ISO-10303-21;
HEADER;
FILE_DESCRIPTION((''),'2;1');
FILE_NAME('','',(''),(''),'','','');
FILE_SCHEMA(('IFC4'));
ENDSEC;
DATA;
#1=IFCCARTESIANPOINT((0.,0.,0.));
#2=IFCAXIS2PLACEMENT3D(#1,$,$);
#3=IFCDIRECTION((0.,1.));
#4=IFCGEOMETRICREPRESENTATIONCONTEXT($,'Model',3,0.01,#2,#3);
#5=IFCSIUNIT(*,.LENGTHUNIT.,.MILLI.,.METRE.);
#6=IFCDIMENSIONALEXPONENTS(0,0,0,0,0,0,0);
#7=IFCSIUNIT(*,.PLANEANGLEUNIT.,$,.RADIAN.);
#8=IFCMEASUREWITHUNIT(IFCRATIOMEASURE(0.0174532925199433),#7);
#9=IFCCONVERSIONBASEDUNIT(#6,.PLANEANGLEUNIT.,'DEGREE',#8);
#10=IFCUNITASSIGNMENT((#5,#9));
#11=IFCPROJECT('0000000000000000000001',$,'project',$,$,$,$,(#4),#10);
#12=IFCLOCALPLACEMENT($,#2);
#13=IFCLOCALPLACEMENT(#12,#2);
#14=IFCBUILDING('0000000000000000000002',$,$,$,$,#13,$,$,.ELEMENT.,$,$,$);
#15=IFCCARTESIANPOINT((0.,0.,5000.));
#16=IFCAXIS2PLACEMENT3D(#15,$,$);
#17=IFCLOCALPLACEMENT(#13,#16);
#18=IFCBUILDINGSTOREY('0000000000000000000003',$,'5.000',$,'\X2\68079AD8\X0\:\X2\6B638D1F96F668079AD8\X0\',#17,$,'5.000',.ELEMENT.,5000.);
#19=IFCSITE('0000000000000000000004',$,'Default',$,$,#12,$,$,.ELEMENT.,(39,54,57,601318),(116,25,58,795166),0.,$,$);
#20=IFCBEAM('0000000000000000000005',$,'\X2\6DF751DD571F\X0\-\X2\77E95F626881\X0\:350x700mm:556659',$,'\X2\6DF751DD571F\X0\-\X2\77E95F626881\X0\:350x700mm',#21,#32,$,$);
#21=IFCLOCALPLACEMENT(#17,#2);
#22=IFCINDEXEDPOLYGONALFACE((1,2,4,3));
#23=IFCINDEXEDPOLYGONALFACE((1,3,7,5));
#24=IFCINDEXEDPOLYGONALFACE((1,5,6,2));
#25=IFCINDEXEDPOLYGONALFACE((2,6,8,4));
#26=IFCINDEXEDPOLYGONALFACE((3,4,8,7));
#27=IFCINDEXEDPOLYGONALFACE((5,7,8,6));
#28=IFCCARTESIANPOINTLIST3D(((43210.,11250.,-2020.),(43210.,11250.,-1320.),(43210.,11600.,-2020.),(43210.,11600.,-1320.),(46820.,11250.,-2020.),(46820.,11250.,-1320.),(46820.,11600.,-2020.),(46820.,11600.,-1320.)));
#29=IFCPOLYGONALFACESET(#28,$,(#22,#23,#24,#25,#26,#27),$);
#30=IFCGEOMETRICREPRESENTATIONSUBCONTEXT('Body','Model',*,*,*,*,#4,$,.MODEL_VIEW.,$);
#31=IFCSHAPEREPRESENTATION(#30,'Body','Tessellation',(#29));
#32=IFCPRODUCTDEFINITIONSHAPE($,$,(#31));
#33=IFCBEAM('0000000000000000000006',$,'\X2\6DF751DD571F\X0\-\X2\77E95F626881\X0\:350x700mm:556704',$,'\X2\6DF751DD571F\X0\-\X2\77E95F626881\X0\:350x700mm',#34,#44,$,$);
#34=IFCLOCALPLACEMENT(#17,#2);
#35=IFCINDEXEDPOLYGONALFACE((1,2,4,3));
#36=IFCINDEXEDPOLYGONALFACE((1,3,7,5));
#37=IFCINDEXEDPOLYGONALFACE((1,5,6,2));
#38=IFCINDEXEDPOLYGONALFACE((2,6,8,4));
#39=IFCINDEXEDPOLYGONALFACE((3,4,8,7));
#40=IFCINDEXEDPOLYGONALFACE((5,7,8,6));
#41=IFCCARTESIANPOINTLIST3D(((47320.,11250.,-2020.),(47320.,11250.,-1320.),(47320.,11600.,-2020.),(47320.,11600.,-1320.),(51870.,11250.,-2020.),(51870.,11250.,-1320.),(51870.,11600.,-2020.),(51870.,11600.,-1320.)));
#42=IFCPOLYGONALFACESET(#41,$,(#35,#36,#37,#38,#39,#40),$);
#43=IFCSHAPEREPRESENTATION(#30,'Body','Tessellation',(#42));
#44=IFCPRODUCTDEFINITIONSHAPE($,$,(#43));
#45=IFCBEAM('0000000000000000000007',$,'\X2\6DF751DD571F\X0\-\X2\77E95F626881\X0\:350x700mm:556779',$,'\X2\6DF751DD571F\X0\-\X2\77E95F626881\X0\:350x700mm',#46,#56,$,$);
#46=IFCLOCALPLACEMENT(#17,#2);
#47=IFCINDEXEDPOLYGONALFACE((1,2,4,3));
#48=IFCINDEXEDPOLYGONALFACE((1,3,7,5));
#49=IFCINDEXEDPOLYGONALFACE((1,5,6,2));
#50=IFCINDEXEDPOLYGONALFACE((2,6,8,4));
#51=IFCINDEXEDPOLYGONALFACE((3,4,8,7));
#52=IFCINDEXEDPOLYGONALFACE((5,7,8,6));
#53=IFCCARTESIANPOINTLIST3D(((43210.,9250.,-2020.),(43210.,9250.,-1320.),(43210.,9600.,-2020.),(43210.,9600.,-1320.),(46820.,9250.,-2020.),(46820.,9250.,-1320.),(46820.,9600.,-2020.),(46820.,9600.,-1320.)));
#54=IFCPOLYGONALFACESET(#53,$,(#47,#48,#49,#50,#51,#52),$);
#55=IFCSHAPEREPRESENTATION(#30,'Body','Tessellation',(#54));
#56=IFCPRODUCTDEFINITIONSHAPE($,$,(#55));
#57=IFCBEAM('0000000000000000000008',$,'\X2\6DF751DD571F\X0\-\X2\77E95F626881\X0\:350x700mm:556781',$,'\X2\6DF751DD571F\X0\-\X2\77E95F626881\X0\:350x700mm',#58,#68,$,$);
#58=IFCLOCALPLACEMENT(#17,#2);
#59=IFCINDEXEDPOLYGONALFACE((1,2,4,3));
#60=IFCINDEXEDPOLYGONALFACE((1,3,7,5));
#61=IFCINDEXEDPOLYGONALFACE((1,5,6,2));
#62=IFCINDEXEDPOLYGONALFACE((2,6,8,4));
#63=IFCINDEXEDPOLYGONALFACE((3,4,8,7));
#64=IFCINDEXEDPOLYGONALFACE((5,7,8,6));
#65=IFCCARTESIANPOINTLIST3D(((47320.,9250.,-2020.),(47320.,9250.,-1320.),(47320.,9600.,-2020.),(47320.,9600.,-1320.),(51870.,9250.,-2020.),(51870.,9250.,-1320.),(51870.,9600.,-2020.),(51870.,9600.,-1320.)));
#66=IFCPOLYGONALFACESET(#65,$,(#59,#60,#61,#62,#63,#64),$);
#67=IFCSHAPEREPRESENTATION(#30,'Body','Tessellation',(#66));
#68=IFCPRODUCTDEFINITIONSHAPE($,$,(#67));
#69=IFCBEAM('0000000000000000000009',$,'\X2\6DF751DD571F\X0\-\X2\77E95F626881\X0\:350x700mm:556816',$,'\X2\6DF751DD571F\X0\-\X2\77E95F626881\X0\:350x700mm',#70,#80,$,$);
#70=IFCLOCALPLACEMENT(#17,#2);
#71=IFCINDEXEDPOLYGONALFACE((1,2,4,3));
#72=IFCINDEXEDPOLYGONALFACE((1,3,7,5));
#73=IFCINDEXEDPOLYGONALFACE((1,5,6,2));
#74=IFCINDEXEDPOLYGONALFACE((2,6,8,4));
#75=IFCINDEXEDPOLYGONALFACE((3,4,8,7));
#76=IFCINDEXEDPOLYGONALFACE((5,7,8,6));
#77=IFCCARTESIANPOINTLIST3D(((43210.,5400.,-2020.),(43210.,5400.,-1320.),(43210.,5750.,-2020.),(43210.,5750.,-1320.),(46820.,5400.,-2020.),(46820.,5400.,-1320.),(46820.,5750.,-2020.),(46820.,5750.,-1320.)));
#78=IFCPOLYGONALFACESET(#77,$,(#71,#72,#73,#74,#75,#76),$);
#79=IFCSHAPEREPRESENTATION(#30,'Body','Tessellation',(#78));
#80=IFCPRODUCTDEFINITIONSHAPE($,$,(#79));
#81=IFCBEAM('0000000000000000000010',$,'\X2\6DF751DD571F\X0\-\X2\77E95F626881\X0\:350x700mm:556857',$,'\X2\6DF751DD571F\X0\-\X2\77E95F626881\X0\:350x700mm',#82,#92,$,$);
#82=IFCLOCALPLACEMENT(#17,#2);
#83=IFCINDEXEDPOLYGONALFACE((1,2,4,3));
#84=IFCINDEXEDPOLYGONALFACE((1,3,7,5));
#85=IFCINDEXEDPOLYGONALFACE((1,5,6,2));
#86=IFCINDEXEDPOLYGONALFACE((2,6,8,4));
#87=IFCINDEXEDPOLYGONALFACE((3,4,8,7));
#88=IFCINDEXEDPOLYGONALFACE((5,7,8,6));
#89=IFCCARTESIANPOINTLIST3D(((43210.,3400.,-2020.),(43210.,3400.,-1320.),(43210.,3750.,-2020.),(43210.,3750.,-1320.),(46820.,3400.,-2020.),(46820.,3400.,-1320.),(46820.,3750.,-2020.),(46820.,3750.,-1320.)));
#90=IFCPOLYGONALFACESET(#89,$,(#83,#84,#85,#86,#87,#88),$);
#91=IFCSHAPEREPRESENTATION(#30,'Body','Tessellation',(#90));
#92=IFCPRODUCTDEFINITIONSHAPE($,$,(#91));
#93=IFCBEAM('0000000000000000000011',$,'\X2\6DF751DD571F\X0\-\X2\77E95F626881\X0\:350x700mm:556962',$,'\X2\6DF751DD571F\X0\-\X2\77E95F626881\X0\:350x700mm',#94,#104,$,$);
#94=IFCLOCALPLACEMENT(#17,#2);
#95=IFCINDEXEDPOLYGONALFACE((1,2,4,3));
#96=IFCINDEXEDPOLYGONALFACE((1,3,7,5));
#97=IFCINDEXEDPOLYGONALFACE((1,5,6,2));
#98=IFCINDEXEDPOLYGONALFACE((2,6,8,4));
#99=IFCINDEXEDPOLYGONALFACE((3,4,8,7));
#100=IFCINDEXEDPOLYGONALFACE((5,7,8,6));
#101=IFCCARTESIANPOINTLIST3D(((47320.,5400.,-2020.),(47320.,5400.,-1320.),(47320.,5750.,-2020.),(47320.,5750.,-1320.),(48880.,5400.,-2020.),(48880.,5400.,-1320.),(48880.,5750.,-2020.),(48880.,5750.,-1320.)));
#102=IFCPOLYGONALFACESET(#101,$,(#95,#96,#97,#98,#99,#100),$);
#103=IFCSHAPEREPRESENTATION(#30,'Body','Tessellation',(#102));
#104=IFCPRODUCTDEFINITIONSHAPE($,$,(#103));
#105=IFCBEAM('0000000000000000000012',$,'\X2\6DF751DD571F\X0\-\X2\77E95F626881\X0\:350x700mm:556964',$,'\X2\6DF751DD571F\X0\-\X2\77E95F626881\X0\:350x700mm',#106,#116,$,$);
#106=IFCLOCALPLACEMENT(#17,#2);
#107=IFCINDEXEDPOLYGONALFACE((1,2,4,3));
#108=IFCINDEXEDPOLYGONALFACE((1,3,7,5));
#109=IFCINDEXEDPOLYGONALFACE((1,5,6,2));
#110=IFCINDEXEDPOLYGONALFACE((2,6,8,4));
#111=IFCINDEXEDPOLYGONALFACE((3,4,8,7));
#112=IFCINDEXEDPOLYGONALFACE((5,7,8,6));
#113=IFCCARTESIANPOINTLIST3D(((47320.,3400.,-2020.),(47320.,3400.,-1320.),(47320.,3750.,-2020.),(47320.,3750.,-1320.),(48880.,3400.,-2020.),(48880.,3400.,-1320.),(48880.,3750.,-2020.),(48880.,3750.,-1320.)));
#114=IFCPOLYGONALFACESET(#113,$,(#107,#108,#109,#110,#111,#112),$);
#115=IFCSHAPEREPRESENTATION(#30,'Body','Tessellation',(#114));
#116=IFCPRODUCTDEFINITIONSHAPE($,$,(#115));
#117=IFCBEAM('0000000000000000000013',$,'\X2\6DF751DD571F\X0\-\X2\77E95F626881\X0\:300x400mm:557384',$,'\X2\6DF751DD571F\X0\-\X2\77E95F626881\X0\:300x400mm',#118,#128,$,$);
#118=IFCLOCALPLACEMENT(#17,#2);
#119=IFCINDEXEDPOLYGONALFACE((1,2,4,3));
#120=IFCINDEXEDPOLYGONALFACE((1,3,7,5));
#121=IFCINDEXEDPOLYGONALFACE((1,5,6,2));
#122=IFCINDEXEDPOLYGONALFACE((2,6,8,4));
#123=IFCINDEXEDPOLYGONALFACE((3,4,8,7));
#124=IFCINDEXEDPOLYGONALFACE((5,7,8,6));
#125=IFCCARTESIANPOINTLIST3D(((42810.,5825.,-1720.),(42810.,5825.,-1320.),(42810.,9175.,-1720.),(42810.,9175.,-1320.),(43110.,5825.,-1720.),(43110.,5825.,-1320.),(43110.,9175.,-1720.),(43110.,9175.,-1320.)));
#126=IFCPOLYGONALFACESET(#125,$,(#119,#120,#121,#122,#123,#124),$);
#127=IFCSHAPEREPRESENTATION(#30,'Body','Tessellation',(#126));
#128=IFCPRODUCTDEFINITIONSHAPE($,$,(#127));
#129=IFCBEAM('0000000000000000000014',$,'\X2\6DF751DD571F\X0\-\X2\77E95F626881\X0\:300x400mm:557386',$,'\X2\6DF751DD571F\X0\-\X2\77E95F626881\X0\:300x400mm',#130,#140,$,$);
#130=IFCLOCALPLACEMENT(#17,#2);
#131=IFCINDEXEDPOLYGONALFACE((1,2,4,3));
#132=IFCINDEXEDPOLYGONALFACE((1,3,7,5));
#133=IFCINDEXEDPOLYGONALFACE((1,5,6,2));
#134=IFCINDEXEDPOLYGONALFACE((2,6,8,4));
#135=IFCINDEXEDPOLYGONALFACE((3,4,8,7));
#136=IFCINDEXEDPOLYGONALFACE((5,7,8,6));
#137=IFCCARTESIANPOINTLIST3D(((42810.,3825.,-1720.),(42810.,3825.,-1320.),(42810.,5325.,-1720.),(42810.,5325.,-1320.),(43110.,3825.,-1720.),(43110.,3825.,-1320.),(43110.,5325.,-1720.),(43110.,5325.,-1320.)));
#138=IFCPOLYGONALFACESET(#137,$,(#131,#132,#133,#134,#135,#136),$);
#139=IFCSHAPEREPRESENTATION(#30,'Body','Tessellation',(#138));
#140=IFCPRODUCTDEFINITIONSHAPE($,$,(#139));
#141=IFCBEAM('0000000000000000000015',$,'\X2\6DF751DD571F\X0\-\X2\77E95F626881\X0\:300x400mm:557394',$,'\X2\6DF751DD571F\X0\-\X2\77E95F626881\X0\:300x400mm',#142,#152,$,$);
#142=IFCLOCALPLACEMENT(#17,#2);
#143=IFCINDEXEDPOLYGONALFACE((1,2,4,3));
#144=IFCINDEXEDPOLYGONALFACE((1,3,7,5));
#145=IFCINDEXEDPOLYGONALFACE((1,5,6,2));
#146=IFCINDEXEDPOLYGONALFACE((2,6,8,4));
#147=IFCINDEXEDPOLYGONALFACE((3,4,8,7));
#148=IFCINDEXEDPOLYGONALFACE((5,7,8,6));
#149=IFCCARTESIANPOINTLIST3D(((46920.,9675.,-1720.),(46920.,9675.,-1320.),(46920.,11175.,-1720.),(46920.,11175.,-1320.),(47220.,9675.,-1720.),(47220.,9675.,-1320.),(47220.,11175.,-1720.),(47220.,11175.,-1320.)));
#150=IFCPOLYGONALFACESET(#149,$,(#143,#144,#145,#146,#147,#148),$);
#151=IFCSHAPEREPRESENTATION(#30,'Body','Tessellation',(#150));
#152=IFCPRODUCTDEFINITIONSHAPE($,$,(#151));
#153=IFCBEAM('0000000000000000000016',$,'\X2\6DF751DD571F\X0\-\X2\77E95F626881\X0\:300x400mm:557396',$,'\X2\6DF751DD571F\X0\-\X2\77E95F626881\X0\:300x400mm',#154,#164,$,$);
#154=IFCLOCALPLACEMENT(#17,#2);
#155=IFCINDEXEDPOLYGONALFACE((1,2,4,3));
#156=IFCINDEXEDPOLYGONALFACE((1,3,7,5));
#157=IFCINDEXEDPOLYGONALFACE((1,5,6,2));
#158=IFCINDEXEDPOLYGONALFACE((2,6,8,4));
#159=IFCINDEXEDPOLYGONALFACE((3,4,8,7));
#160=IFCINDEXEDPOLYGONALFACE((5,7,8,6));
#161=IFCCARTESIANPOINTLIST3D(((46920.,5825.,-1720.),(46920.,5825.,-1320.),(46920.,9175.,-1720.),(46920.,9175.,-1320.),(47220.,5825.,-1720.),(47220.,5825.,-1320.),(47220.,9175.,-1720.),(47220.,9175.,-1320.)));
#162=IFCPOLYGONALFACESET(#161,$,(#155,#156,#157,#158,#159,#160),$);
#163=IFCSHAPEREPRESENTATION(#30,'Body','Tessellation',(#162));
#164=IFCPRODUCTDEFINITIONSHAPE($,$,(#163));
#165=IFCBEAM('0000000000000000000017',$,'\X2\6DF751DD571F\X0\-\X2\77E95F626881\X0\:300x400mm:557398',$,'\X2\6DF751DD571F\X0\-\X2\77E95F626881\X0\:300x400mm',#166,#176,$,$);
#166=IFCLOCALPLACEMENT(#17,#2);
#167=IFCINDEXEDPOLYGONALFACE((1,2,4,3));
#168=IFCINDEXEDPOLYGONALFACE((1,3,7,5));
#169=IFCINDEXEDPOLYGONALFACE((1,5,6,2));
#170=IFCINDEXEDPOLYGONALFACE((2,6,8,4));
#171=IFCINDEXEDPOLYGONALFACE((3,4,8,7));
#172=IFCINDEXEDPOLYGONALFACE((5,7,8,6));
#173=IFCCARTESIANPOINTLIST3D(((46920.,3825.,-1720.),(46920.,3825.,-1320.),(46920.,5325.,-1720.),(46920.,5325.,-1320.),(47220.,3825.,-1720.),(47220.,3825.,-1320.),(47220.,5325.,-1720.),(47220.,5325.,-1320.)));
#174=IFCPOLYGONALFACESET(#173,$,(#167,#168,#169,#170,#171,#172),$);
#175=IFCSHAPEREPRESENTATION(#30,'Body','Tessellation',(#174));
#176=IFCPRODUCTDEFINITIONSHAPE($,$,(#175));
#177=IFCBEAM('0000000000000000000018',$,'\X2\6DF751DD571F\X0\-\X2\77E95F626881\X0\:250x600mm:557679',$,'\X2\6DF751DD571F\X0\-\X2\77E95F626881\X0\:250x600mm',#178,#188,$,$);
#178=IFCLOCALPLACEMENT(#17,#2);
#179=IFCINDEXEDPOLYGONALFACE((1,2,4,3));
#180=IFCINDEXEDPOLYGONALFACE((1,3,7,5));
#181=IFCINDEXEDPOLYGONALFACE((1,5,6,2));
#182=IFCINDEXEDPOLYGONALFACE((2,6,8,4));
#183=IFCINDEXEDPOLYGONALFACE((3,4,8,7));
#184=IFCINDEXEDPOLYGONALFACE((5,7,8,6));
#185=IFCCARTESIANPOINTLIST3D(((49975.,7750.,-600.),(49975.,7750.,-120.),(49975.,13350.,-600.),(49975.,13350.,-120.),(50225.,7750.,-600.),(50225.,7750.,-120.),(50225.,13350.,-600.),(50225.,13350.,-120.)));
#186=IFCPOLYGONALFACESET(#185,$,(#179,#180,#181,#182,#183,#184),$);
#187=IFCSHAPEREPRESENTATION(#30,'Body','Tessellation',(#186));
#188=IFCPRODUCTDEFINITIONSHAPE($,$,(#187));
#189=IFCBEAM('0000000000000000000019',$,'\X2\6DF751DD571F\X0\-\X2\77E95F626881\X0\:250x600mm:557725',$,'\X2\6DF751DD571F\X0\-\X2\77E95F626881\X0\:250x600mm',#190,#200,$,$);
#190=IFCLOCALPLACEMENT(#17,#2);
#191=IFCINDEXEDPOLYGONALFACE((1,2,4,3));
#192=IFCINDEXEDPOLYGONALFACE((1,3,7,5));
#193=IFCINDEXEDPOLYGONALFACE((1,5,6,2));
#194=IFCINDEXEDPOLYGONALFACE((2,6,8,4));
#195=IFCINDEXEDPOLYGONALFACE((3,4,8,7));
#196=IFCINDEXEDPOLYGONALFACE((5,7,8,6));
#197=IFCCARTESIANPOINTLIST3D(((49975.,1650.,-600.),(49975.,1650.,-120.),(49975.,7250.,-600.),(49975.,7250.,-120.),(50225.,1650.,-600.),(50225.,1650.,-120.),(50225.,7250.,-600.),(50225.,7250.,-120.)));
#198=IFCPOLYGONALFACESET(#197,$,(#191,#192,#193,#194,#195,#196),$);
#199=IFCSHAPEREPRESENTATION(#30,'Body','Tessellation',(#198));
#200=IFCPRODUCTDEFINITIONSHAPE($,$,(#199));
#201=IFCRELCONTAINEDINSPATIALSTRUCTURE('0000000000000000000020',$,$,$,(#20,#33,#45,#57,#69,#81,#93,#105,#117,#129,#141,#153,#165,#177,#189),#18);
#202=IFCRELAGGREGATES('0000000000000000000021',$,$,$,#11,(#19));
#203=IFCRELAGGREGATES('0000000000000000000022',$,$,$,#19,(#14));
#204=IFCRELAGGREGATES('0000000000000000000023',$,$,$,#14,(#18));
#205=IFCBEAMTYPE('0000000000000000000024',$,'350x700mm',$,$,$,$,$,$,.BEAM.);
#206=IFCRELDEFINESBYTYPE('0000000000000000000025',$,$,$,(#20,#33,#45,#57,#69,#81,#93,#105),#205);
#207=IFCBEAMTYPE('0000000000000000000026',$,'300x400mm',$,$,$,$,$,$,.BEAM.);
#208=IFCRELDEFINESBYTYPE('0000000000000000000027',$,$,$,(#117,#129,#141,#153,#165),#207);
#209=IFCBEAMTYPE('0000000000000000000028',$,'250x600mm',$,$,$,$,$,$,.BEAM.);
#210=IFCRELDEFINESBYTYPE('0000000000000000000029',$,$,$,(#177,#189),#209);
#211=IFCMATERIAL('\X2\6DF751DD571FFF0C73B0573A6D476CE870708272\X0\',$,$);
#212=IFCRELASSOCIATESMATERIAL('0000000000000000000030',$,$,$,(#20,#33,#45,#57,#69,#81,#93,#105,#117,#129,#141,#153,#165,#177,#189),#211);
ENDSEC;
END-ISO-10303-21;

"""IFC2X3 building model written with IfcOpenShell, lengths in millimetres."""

from ifc_helpers import new_model, entity, si_unit, converted_unit, direction, frame, frame_2d, origin, origin_2d_with_axis, place, context, subcontext, project, spatial, rectangle, extrude, material, type_object, element, save


model = new_model("IFC2X3")

# Units and contexts
model_context = context("Model", 3, precision=0.01, world=origin(), true_north=direction((0.0, 1.0)))
body_context = subcontext(model_context, "Body", "Model", "MODEL_VIEW")
ifc_project = project(units=[si_unit("LENGTHUNIT", "METRE", prefix="MILLI"), converted_unit("PLANEANGLEUNIT", "DEGREE", entity("IfcRatioMeasure", 0.0174532925199433), si_unit("PLANEANGLEUNIT", "RADIAN"), dimensions=[0, 0, 0, 0, 0, 0, 0])], contexts=[model_context])

# Site, building, storey
site_placement = place(None, origin())
site = spatial("IfcSite", under=ifc_project, at=site_placement, Name="Default", CompositionType="ELEMENT", RefLatitude=(39, 54, 57, 601318), RefLongitude=(116, 25, 58, 795166), RefElevation=0.0)
building_placement = place(site_placement, origin())
building = spatial("IfcBuilding", under=site, at=building_placement, CompositionType="ELEMENT")
storey_placement = place(building_placement, frame((0.0, 0.0, 5000.0)))
storey = spatial("IfcBuildingStorey", under=building, at=storey_placement, Name="5.000", ObjectType="标高:正负零标高", LongName="5.000", CompositionType="ELEMENT", Elevation=5000.0)

# Beams
ifc_material_1 = material(Name="混凝土，现场浇注灰色")
beam_type_1 = type_object("IfcBeamType", Name="350x700mm", PredefinedType="BEAM")
beam_1_placement = place(storey_placement, frame((43210.0, 11425.0, -1320.0)))
element("IfcBeam", 1, at=beam_1_placement, inside=storey, type_object=beam_type_1, material=ifc_material_1, Name="混凝土-矩形梁:350x700mm:556659", ObjectType="混凝土-矩形梁:350x700mm", context=body_context, shape_type="SweptSolid", body=[
    extrude(rectangle(XDim=700.0, YDim=350.0, at=frame_2d((0.0, 0.0), x_axis=(1.0, 0.0))), frame((0.0, 0.0, -350.0), z_axis=(1.0, 0.0, 0.0), x_axis=(0.0, 0.0, -1.0)), (0.0, 0.0, 1.0), 3610.0),
])
beam_2_placement = place(storey_placement, frame((47320.0, 11425.0, -1320.0)))
element("IfcBeam", 2, at=beam_2_placement, inside=storey, type_object=beam_type_1, material=ifc_material_1, Name="混凝土-矩形梁:350x700mm:556704", ObjectType="混凝土-矩形梁:350x700mm", context=body_context, shape_type="SweptSolid", body=[
    extrude(rectangle(XDim=700.0, YDim=350.0, at=frame_2d((0.0, 0.0), x_axis=(1.0, 0.0))), frame((0.0, 0.0, -350.0), z_axis=(1.0, 0.0, 0.0), x_axis=(0.0, 0.0, -1.0)), (0.0, 0.0, 1.0), 4550.0),
])
beam_3_placement = place(storey_placement, frame((43210.0, 9425.0, -1320.0)))
element("IfcBeam", 3, at=beam_3_placement, inside=storey, type_object=beam_type_1, material=ifc_material_1, Name="混凝土-矩形梁:350x700mm:556779", ObjectType="混凝土-矩形梁:350x700mm", context=body_context, shape_type="SweptSolid", body=[
    extrude(rectangle(XDim=700.0, YDim=350.0, at=frame_2d((0.0, 0.0), x_axis=(1.0, 0.0))), frame((0.0, 0.0, -350.0), z_axis=(1.0, 0.0, 0.0), x_axis=(0.0, 0.0, -1.0)), (0.0, 0.0, 1.0), 3610.0),
])
beam_4_placement = place(storey_placement, frame((47320.0, 9425.0, -1320.0)))
element("IfcBeam", 4, at=beam_4_placement, inside=storey, type_object=beam_type_1, material=ifc_material_1, Name="混凝土-矩形梁:350x700mm:556781", ObjectType="混凝土-矩形梁:350x700mm", context=body_context, shape_type="SweptSolid", body=[
    extrude(rectangle(XDim=700.0, YDim=350.0, at=frame_2d((0.0, 0.0), x_axis=(1.0, 0.0))), frame((0.0, 0.0, -350.0), z_axis=(1.0, 0.0, 0.0), x_axis=(0.0, 0.0, -1.0)), (0.0, 0.0, 1.0), 4550.0),
])
for number, where, name in (
    (5, (43210.0, 5575.0, -1320.0), "混凝土-矩形梁:350x700mm:556816"),
    (6, (43210.0, 3575.0, -1320.0), "混凝土-矩形梁:350x700mm:556857"),
):
    element("IfcBeam", number, at=place(storey_placement, frame(where)), inside=storey, type_object=beam_type_1, material=ifc_material_1, Name=name, ObjectType="混凝土-矩形梁:350x700mm", context=body_context, shape_type="SweptSolid", body=[
        extrude(rectangle(XDim=700.0, YDim=350.0, at=frame_2d((0.0, 0.0), x_axis=(1.0, 0.0))), frame((0.0, 0.0, -350.0), z_axis=(1.0, 0.0, 0.0), x_axis=(0.0, 0.0, -1.0)), (0.0, 0.0, 1.0), 3610.0),
    ])
beam_5_placement = place(storey_placement, frame((47320.0, 5575.0, -1320.0)))
element("IfcBeam", 7, at=beam_5_placement, inside=storey, type_object=beam_type_1, material=ifc_material_1, Name="混凝土-矩形梁:350x700mm:556962", ObjectType="混凝土-矩形梁:350x700mm", context=body_context, shape_type="SweptSolid", body=[
    extrude(rectangle(XDim=700.0, YDim=350.0, at=frame_2d((0.0, 0.0), x_axis=(1.0, 0.0))), frame((0.0, 0.0, -350.0), z_axis=(1.0, 0.0, 0.0), x_axis=(0.0, 0.0, -1.0)), (0.0, 0.0, 1.0), 1560.0),
])
beam_6_placement = place(storey_placement, frame((47320.0, 3575.0, -1320.0)))
element("IfcBeam", 8, at=beam_6_placement, inside=storey, type_object=beam_type_1, material=ifc_material_1, Name="混凝土-矩形梁:350x700mm:556964", ObjectType="混凝土-矩形梁:350x700mm", context=body_context, shape_type="SweptSolid", body=[
    extrude(rectangle(XDim=700.0, YDim=350.0, at=frame_2d((0.0, 0.0), x_axis=(1.0, 0.0))), frame((0.0, 0.0, -350.0), z_axis=(1.0, 0.0, 0.0), x_axis=(0.0, 0.0, -1.0)), (0.0, 0.0, 1.0), 1560.0),
])
beam_type_2 = type_object("IfcBeamType", Name="300x400mm", PredefinedType="BEAM")
beam_7_placement = place(storey_placement, frame((42960.0, 9175.0, -1320.0), z_axis=(0.0, 0.0, 1.0), x_axis=(0.0, -1.0, 0.0)))
element("IfcBeam", 9, at=beam_7_placement, inside=storey, type_object=beam_type_2, material=ifc_material_1, Name="混凝土-矩形梁:300x400mm:557384", ObjectType="混凝土-矩形梁:300x400mm", context=body_context, shape_type="SweptSolid", body=[
    extrude(rectangle(XDim=400.0, YDim=300.0, at=origin_2d_with_axis()), frame((0.0, 0.0, -200.0), z_axis=(1.0, 0.0, 0.0), x_axis=(0.0, 0.0, -1.0)), (0.0, 0.0, 1.0), 3350.0),
])
beam_8_placement = place(storey_placement, frame((42960.0, 5325.0, -1320.0), z_axis=(0.0, 0.0, 1.0), x_axis=(0.0, -1.0, 0.0)))
element("IfcBeam", 10, at=beam_8_placement, inside=storey, type_object=beam_type_2, material=ifc_material_1, Name="混凝土-矩形梁:300x400mm:557386", ObjectType="混凝土-矩形梁:300x400mm", context=body_context, shape_type="SweptSolid", body=[
    extrude(rectangle(XDim=400.0, YDim=300.0, at=frame_2d((0.0, 0.0), x_axis=(1.0, 0.0))), frame((0.0, 0.0, -200.0), z_axis=(1.0, 0.0, 0.0), x_axis=(0.0, 0.0, -1.0)), (0.0, 0.0, 1.0), 1500.0),
])
beam_9_placement = place(storey_placement, frame((47070.0, 11175.0, -1320.0), z_axis=(0.0, 0.0, 1.0), x_axis=(0.0, -1.0, 0.0)))
element("IfcBeam", 11, at=beam_9_placement, inside=storey, type_object=beam_type_2, material=ifc_material_1, Name="混凝土-矩形梁:300x400mm:557394", ObjectType="混凝土-矩形梁:300x400mm", context=body_context, shape_type="SweptSolid", body=[
    extrude(rectangle(XDim=400.0, YDim=300.0, at=frame_2d((0.0, 0.0), x_axis=(1.0, 0.0))), frame((0.0, 0.0, -200.0), z_axis=(1.0, 0.0, 0.0), x_axis=(0.0, 0.0, -1.0)), (0.0, 0.0, 1.0), 1500.0),
])
beam_10_placement = place(storey_placement, frame((47070.0, 9175.0, -1320.0), z_axis=(0.0, 0.0, 1.0), x_axis=(0.0, -1.0, 0.0)))
element("IfcBeam", 12, at=beam_10_placement, inside=storey, type_object=beam_type_2, material=ifc_material_1, Name="混凝土-矩形梁:300x400mm:557396", ObjectType="混凝土-矩形梁:300x400mm", context=body_context, shape_type="SweptSolid", body=[
    extrude(rectangle(XDim=400.0, YDim=300.0, at=origin_2d_with_axis()), frame((0.0, 0.0, -200.0), z_axis=(1.0, 0.0, 0.0), x_axis=(0.0, 0.0, -1.0)), (0.0, 0.0, 1.0), 3350.0),
])
beam_11_placement = place(storey_placement, frame((47070.0, 5325.0, -1320.0), z_axis=(0.0, 0.0, 1.0), x_axis=(0.0, -1.0, 0.0)))
element("IfcBeam", 13, at=beam_11_placement, inside=storey, type_object=beam_type_2, material=ifc_material_1, Name="混凝土-矩形梁:300x400mm:557398", ObjectType="混凝土-矩形梁:300x400mm", context=body_context, shape_type="SweptSolid", body=[
    extrude(rectangle(XDim=400.0, YDim=300.0, at=frame_2d((0.0, 0.0), x_axis=(1.0, 0.0))), frame((0.0, 0.0, -200.0), z_axis=(1.0, 0.0, 0.0), x_axis=(0.0, 0.0, -1.0)), (0.0, 0.0, 1.0), 1500.0),
])
beam_type_3 = type_object("IfcBeamType", Name="250x600mm", PredefinedType="BEAM")
for number, where, z_axis, x_axis, name in (
    (14, (50100.0, 13600.0, 0.0), (0.0, 0.0, 1.0), (0.0, -1.0, 0.0), "混凝土-矩形梁:250x600mm:557679"),
    (15, (50100.0, 7500.0, 0.0), (0.0, 0.0, 1.0), (0.0, -1.0, 0.0), "混凝土-矩形梁:250x600mm:557725"),
):
    element("IfcBeam", number, at=place(storey_placement, frame(where, z_axis=z_axis, x_axis=x_axis)), inside=storey, type_object=beam_type_3, material=ifc_material_1, Name=name, ObjectType="混凝土-矩形梁:250x600mm", context=body_context, shape_type="SweptSolid", body=[
        extrude(rectangle(XDim=480.0, YDim=250.0, at=frame_2d((0.0, 0.0), x_axis=(1.0, 0.0))), frame((250.0, 0.0, -360.0), z_axis=(1.0, 0.0, 0.0), x_axis=(0.0, 0.0, -1.0)), (0.0, 0.0, 1.0), 5600.0),
    ])

save(model, "model.ifc")
